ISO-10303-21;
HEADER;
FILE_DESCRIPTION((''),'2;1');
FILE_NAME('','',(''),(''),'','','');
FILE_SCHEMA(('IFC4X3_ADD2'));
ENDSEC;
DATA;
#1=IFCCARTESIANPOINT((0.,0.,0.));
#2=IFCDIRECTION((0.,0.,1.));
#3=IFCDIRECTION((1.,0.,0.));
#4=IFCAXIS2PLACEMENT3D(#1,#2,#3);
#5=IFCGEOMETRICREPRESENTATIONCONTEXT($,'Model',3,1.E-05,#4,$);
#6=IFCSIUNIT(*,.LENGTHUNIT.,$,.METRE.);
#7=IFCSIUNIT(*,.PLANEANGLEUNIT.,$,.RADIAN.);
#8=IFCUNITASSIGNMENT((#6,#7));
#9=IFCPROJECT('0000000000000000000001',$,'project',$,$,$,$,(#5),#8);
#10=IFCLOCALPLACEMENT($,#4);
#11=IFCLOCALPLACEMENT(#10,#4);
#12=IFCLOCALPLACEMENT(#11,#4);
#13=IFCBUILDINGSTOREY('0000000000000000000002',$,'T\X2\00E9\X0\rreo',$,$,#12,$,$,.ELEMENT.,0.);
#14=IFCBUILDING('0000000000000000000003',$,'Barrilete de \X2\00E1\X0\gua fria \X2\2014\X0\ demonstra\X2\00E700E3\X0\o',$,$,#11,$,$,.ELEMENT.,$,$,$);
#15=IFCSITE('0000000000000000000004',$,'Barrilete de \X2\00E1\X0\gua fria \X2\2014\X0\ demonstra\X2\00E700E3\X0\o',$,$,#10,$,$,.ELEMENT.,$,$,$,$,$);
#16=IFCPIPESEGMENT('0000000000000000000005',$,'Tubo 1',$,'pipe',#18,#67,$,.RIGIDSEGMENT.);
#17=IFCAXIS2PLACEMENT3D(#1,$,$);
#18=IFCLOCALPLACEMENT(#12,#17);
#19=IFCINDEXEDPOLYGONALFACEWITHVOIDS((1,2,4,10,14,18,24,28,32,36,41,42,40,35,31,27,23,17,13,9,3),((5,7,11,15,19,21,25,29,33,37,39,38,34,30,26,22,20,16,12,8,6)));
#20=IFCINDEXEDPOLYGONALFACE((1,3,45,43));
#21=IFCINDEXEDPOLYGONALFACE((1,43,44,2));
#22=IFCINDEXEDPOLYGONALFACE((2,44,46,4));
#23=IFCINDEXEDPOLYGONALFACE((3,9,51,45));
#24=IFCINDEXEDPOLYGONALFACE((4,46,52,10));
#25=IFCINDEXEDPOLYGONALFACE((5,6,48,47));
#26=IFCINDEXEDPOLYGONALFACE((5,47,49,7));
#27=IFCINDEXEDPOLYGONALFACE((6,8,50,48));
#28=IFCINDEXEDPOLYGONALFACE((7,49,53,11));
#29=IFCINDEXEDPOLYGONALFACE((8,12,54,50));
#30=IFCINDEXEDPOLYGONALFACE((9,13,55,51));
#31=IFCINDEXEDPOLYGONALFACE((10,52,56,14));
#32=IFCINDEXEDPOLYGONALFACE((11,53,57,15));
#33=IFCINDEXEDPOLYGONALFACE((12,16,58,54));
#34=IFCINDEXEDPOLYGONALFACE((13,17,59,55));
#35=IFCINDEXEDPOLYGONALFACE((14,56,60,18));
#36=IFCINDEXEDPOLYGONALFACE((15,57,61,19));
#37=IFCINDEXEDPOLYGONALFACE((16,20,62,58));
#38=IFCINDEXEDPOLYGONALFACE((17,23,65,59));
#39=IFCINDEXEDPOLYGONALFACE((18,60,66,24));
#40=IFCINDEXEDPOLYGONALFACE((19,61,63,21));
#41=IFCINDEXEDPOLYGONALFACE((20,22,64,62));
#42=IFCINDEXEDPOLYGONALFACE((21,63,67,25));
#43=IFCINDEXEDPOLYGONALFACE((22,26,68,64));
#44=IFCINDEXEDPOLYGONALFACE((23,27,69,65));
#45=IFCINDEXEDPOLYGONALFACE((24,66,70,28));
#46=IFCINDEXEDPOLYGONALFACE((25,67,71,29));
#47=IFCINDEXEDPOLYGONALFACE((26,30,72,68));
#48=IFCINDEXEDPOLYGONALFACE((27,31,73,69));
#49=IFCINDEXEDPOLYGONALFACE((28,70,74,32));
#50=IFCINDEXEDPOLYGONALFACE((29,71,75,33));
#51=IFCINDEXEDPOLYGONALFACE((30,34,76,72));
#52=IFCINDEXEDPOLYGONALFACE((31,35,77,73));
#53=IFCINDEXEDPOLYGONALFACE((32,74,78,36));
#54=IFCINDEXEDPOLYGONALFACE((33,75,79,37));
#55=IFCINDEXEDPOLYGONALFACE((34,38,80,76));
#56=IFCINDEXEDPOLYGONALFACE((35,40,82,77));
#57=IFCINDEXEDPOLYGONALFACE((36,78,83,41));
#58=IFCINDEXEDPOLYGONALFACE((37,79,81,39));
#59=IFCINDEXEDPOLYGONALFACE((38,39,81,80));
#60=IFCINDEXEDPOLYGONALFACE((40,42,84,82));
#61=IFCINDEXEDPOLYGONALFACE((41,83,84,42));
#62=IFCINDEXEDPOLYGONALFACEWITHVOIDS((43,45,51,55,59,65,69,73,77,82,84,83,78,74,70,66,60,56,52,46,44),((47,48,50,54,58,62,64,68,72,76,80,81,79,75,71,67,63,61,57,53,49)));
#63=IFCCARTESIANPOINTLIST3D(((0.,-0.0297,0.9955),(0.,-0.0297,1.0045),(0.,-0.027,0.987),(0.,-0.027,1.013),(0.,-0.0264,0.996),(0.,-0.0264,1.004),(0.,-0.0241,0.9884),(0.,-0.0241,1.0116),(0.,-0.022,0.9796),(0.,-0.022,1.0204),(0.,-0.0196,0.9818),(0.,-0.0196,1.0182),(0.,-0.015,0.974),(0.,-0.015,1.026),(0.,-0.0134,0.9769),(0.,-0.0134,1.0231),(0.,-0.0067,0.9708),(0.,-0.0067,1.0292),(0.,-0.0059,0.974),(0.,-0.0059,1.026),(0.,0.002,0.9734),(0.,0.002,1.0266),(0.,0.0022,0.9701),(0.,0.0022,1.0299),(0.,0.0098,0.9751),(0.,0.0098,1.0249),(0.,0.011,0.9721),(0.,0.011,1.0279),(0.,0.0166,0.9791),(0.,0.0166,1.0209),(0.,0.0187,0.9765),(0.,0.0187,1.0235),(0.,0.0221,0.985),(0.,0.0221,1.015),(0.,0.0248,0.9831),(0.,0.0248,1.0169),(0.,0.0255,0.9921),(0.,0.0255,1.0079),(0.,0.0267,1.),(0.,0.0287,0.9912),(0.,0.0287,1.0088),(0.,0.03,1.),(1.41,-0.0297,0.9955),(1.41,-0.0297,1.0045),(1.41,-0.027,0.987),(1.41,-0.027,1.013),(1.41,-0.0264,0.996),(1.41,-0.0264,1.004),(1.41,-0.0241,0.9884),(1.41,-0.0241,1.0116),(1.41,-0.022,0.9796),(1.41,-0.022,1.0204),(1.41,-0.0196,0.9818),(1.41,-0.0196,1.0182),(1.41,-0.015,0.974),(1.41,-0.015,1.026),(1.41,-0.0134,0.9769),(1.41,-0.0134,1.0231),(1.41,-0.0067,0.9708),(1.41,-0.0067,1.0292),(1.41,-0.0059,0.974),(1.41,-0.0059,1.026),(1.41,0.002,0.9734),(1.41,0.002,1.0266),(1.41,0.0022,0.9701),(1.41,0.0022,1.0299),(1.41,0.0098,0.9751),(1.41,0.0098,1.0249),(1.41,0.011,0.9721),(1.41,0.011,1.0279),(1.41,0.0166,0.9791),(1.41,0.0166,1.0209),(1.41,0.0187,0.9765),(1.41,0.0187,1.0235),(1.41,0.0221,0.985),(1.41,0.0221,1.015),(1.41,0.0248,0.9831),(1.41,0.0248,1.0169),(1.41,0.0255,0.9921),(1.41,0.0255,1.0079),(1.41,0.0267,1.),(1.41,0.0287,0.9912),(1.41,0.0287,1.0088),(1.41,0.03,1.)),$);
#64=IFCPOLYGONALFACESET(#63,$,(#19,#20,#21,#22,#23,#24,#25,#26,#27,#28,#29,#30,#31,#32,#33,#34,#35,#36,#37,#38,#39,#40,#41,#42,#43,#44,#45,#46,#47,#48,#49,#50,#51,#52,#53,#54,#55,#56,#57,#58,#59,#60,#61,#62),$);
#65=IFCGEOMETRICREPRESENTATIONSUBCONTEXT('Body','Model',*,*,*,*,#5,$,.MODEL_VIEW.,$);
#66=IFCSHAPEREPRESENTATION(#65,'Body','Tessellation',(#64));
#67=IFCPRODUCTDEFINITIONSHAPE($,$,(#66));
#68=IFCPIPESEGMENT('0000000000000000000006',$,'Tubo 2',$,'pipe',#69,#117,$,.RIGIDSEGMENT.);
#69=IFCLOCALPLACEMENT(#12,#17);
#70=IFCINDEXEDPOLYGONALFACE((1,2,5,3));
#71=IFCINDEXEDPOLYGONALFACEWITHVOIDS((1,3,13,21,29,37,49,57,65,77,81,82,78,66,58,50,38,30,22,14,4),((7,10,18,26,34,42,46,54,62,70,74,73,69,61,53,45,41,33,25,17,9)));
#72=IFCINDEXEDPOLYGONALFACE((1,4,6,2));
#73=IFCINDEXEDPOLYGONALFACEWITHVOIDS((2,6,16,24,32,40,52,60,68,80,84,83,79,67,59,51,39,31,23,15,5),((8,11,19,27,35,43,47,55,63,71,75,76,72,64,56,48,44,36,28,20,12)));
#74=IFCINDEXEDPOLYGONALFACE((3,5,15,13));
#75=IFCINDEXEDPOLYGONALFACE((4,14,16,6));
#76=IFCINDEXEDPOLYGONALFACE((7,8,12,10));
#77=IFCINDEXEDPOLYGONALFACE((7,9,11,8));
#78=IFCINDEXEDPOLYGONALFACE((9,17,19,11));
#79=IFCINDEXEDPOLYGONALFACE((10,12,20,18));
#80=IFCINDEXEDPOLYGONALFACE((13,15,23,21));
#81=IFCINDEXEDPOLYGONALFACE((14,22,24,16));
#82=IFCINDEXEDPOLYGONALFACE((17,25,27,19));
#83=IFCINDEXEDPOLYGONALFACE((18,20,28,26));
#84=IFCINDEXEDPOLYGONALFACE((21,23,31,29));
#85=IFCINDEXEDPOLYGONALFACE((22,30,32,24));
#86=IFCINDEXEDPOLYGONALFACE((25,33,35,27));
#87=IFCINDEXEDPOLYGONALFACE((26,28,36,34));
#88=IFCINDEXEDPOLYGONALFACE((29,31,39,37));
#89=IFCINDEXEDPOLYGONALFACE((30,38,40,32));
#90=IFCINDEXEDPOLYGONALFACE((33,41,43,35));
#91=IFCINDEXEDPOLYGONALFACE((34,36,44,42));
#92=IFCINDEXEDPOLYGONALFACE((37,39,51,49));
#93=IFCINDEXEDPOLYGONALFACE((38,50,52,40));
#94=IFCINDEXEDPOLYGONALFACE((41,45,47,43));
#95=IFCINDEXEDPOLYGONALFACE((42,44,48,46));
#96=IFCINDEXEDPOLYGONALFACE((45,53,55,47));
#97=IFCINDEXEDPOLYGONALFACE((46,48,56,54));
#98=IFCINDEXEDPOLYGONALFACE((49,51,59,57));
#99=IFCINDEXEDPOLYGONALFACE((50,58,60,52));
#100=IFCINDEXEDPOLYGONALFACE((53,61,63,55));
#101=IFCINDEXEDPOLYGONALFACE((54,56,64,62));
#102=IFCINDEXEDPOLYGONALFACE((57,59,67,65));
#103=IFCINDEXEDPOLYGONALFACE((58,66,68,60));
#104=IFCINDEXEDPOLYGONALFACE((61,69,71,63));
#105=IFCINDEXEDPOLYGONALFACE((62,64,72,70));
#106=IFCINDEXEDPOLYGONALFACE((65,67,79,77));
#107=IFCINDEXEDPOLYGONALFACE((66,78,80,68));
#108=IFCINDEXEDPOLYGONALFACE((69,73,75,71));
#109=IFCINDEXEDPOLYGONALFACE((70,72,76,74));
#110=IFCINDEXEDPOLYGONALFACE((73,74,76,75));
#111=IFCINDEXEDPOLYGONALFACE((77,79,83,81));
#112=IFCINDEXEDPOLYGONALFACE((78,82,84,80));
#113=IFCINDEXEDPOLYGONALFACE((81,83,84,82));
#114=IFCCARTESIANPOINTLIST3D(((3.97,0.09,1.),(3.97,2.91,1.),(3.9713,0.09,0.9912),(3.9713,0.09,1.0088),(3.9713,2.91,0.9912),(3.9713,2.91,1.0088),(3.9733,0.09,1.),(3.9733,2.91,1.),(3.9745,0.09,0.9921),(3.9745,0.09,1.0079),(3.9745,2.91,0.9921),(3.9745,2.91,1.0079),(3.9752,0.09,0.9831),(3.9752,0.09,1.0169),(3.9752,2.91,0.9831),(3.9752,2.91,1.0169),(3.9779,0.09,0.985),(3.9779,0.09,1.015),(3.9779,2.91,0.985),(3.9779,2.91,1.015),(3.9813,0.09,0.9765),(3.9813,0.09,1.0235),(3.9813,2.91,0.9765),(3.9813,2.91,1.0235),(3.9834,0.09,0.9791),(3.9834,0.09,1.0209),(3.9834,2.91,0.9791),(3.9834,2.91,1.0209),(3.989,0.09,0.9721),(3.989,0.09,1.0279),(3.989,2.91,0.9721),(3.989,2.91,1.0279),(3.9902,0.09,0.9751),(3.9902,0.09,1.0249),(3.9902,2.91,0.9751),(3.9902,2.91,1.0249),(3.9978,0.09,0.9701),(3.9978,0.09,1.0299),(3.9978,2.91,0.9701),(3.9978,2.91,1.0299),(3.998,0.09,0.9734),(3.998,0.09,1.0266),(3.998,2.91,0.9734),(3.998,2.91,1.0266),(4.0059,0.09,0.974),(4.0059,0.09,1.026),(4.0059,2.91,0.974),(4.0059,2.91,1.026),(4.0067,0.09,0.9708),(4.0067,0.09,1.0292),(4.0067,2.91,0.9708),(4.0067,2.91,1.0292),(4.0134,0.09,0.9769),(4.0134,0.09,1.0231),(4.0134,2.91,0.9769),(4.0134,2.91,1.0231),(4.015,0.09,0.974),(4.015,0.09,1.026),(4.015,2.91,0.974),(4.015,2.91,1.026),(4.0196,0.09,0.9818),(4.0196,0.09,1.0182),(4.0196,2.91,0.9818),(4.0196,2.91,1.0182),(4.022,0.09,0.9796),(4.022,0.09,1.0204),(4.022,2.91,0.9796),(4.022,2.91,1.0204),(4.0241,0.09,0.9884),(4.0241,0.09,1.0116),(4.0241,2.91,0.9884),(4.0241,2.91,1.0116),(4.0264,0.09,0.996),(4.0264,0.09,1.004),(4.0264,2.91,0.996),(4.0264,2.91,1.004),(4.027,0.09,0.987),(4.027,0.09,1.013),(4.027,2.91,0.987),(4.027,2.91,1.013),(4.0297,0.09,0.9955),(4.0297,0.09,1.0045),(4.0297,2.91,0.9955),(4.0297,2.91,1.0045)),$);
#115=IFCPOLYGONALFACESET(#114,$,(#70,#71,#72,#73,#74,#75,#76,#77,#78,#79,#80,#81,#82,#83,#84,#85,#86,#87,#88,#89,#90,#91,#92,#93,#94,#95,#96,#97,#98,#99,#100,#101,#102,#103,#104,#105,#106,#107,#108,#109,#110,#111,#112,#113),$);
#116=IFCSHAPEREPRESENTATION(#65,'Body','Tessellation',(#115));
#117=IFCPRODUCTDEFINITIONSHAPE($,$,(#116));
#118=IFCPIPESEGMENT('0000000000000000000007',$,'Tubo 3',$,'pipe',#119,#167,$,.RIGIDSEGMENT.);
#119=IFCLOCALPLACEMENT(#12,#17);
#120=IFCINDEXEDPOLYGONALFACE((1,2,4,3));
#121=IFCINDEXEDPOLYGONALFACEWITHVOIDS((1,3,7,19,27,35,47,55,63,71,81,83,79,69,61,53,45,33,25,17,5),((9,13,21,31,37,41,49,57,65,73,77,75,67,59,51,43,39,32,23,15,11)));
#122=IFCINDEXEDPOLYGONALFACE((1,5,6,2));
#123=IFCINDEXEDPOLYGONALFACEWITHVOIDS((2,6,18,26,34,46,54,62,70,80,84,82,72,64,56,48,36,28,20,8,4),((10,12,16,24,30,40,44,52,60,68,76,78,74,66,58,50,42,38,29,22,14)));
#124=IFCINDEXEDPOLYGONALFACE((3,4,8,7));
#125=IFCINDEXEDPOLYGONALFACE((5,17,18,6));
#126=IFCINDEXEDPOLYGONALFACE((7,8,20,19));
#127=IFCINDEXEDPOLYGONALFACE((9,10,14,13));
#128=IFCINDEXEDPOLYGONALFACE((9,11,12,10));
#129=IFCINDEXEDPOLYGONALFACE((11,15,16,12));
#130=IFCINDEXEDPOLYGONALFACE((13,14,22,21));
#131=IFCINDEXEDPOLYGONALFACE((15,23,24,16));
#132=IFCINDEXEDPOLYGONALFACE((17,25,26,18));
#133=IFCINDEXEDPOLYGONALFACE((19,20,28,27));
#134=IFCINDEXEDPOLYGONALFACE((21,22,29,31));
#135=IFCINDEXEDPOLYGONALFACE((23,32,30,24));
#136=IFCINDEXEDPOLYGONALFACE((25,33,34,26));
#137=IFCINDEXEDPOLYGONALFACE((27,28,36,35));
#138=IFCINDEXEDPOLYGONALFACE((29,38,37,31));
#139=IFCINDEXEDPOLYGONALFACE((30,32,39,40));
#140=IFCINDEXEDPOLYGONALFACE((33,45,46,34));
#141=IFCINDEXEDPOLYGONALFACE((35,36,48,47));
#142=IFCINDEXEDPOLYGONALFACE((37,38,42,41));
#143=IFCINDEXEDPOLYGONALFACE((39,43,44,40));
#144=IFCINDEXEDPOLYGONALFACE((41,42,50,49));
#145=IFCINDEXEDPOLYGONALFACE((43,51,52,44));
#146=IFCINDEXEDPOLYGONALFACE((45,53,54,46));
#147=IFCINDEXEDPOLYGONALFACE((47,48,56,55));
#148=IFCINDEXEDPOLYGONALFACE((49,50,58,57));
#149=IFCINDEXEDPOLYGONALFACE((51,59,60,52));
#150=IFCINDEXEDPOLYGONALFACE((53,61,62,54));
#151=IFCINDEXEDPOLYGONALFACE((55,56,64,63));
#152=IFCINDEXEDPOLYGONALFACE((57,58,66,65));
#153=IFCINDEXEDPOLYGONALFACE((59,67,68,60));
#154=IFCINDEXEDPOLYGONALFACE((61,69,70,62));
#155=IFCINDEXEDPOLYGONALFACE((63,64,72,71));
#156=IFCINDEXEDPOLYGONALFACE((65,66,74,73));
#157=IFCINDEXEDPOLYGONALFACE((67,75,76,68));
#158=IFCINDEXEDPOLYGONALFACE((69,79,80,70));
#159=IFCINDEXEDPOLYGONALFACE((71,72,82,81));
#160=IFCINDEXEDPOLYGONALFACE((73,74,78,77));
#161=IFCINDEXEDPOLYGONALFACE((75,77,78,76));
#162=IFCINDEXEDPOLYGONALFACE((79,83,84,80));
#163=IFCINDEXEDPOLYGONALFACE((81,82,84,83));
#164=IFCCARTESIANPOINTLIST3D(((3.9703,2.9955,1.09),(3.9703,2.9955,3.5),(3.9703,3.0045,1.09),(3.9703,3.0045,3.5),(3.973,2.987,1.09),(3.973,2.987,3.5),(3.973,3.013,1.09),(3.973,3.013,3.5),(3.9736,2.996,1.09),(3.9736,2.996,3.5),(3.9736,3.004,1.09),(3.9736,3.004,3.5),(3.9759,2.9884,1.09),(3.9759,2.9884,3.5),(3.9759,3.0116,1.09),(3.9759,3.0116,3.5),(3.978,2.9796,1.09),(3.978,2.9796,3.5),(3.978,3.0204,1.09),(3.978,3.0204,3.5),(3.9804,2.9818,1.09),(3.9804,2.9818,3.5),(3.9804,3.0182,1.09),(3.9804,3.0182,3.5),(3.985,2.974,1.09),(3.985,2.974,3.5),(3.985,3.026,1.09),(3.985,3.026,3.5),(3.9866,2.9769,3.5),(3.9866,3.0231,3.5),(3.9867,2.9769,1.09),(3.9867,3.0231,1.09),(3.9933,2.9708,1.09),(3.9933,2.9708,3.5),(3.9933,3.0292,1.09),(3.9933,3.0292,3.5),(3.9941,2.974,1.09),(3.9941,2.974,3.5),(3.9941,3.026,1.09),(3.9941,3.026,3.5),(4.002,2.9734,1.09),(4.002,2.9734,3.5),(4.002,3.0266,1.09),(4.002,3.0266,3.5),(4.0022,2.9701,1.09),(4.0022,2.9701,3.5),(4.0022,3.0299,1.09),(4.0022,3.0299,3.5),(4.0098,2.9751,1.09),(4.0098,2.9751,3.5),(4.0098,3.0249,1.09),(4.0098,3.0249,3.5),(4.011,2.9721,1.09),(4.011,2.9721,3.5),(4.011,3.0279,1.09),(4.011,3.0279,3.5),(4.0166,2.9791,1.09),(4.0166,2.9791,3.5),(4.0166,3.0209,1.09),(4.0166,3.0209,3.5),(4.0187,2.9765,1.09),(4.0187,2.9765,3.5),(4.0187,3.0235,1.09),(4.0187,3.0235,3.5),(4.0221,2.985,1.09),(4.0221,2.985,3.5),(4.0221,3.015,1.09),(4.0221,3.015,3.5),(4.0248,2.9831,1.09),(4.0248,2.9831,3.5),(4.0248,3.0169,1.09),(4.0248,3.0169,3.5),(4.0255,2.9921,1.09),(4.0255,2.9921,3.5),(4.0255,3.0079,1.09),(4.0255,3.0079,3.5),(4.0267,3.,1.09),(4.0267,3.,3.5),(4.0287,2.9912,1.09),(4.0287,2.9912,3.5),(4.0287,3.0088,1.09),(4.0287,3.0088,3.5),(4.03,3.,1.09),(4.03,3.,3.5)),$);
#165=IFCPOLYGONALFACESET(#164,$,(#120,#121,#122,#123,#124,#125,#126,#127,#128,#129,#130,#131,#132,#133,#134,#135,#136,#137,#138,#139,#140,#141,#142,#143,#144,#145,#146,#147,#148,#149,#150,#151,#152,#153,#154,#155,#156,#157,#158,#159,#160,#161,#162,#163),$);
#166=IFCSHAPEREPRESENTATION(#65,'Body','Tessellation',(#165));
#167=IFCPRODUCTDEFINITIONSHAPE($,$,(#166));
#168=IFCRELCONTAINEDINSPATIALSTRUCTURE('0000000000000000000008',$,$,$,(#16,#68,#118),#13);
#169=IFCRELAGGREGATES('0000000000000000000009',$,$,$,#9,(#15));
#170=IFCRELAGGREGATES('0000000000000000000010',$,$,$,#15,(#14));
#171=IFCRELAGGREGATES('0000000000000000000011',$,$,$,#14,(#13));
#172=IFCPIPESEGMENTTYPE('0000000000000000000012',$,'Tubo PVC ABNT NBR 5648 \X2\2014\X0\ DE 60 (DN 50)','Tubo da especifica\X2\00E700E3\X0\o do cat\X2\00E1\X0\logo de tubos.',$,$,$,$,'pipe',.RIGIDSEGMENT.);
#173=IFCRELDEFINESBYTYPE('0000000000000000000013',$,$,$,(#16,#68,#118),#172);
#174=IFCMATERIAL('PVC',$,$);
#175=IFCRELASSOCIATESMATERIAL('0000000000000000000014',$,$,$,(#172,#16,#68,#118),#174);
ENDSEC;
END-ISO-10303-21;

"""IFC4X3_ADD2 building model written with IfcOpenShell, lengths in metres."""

from ifc_helpers import new_model, si_unit, frame, origin_with_axes, place, context, subcontext, project, spatial, hollow_circle, extrude, material, type_object, element, save


model = new_model("IFC4X3_ADD2")

# Units and contexts
model_context = context("Model", 3, precision=1e-05, world=origin_with_axes())
body_context = subcontext(model_context, "Body", "Model", "MODEL_VIEW")
ifc_project = project(units=[si_unit("LENGTHUNIT", "METRE"), si_unit("PLANEANGLEUNIT", "RADIAN")], contexts=[model_context])

# Site, building, storey
site_placement = place(None, origin_with_axes())
site = spatial("IfcSite", under=ifc_project, at=site_placement, Name="Barrilete de água fria — demonstração", CompositionType="ELEMENT")
building_placement = place(site_placement, origin_with_axes())
building = spatial("IfcBuilding", under=site, at=building_placement, Name="Barrilete de água fria — demonstração", CompositionType="ELEMENT")
storey_placement = place(building_placement, origin_with_axes())
storey = spatial("IfcBuildingStorey", under=building, at=storey_placement, Name="Térreo", CompositionType="ELEMENT", Elevation=0.0)

# Pipe segments
ifc_material = material(Name="PVC")
pipe_segment_type_1 = type_object("IfcPipeSegmentType", Name="Tubo PVC ABNT NBR 5648 — DE 60 (DN 50)", Description="Tubo da especificação do catálogo de tubos.", ElementType="pipe", PredefinedType="RIGIDSEGMENT", material=ifc_material)
pipe_segment_1_placement = place(storey_placement, frame((0.0, 0.0, 1.0), z_axis=(0.0, 0.0, 1.0), x_axis=(1.0, 0.0, 0.0)))
element("IfcPipeSegment", 1, at=pipe_segment_1_placement, inside=storey, type_object=pipe_segment_type_1, material=ifc_material, Name="Tubo 1", ObjectType="pipe", PredefinedType="RIGIDSEGMENT", context=body_context, shape_type="SweptSolid", body=[
    extrude(hollow_circle(Radius=0.03, WallThickness=0.0033), frame((0.0, 0.0, 0.0), z_axis=(1.0, 0.0, 0.0), x_axis=(0.0, 1.0, 0.0)), (0.0, 0.0, 1.0), 1.41),
])
pipe_segment_2_placement = place(storey_placement, frame((4.0, 0.09, 1.0), z_axis=(0.0, 0.0, 1.0), x_axis=(0.0, 1.0, 0.0)))
element("IfcPipeSegment", 2, at=pipe_segment_2_placement, inside=storey, type_object=pipe_segment_type_1, material=ifc_material, Name="Tubo 2", ObjectType="pipe", PredefinedType="RIGIDSEGMENT", context=body_context, shape_type="SweptSolid", body=[
    extrude(hollow_circle(Radius=0.03, WallThickness=0.0033), frame((0.0, 0.0, 0.0), z_axis=(1.0, 0.0, 0.0), x_axis=(0.0, 1.0, 0.0)), (0.0, 0.0, 1.0), 2.82),
])
pipe_segment_3_placement = place(storey_placement, frame((4.0, 3.0, 1.09), z_axis=(0.0, 1.0, 0.0), x_axis=(0.0, 0.0, 1.0)))
element("IfcPipeSegment", 3, at=pipe_segment_3_placement, inside=storey, type_object=pipe_segment_type_1, material=ifc_material, Name="Tubo 3", ObjectType="pipe", PredefinedType="RIGIDSEGMENT", context=body_context, shape_type="SweptSolid", body=[
    extrude(hollow_circle(Radius=0.03, WallThickness=0.0033), frame((0.0, 0.0, 0.0), z_axis=(1.0, 0.0, 0.0), x_axis=(0.0, 1.0, 0.0)), (0.0, 0.0, 1.0), 2.41),
])

save(model, "model.ifc")
